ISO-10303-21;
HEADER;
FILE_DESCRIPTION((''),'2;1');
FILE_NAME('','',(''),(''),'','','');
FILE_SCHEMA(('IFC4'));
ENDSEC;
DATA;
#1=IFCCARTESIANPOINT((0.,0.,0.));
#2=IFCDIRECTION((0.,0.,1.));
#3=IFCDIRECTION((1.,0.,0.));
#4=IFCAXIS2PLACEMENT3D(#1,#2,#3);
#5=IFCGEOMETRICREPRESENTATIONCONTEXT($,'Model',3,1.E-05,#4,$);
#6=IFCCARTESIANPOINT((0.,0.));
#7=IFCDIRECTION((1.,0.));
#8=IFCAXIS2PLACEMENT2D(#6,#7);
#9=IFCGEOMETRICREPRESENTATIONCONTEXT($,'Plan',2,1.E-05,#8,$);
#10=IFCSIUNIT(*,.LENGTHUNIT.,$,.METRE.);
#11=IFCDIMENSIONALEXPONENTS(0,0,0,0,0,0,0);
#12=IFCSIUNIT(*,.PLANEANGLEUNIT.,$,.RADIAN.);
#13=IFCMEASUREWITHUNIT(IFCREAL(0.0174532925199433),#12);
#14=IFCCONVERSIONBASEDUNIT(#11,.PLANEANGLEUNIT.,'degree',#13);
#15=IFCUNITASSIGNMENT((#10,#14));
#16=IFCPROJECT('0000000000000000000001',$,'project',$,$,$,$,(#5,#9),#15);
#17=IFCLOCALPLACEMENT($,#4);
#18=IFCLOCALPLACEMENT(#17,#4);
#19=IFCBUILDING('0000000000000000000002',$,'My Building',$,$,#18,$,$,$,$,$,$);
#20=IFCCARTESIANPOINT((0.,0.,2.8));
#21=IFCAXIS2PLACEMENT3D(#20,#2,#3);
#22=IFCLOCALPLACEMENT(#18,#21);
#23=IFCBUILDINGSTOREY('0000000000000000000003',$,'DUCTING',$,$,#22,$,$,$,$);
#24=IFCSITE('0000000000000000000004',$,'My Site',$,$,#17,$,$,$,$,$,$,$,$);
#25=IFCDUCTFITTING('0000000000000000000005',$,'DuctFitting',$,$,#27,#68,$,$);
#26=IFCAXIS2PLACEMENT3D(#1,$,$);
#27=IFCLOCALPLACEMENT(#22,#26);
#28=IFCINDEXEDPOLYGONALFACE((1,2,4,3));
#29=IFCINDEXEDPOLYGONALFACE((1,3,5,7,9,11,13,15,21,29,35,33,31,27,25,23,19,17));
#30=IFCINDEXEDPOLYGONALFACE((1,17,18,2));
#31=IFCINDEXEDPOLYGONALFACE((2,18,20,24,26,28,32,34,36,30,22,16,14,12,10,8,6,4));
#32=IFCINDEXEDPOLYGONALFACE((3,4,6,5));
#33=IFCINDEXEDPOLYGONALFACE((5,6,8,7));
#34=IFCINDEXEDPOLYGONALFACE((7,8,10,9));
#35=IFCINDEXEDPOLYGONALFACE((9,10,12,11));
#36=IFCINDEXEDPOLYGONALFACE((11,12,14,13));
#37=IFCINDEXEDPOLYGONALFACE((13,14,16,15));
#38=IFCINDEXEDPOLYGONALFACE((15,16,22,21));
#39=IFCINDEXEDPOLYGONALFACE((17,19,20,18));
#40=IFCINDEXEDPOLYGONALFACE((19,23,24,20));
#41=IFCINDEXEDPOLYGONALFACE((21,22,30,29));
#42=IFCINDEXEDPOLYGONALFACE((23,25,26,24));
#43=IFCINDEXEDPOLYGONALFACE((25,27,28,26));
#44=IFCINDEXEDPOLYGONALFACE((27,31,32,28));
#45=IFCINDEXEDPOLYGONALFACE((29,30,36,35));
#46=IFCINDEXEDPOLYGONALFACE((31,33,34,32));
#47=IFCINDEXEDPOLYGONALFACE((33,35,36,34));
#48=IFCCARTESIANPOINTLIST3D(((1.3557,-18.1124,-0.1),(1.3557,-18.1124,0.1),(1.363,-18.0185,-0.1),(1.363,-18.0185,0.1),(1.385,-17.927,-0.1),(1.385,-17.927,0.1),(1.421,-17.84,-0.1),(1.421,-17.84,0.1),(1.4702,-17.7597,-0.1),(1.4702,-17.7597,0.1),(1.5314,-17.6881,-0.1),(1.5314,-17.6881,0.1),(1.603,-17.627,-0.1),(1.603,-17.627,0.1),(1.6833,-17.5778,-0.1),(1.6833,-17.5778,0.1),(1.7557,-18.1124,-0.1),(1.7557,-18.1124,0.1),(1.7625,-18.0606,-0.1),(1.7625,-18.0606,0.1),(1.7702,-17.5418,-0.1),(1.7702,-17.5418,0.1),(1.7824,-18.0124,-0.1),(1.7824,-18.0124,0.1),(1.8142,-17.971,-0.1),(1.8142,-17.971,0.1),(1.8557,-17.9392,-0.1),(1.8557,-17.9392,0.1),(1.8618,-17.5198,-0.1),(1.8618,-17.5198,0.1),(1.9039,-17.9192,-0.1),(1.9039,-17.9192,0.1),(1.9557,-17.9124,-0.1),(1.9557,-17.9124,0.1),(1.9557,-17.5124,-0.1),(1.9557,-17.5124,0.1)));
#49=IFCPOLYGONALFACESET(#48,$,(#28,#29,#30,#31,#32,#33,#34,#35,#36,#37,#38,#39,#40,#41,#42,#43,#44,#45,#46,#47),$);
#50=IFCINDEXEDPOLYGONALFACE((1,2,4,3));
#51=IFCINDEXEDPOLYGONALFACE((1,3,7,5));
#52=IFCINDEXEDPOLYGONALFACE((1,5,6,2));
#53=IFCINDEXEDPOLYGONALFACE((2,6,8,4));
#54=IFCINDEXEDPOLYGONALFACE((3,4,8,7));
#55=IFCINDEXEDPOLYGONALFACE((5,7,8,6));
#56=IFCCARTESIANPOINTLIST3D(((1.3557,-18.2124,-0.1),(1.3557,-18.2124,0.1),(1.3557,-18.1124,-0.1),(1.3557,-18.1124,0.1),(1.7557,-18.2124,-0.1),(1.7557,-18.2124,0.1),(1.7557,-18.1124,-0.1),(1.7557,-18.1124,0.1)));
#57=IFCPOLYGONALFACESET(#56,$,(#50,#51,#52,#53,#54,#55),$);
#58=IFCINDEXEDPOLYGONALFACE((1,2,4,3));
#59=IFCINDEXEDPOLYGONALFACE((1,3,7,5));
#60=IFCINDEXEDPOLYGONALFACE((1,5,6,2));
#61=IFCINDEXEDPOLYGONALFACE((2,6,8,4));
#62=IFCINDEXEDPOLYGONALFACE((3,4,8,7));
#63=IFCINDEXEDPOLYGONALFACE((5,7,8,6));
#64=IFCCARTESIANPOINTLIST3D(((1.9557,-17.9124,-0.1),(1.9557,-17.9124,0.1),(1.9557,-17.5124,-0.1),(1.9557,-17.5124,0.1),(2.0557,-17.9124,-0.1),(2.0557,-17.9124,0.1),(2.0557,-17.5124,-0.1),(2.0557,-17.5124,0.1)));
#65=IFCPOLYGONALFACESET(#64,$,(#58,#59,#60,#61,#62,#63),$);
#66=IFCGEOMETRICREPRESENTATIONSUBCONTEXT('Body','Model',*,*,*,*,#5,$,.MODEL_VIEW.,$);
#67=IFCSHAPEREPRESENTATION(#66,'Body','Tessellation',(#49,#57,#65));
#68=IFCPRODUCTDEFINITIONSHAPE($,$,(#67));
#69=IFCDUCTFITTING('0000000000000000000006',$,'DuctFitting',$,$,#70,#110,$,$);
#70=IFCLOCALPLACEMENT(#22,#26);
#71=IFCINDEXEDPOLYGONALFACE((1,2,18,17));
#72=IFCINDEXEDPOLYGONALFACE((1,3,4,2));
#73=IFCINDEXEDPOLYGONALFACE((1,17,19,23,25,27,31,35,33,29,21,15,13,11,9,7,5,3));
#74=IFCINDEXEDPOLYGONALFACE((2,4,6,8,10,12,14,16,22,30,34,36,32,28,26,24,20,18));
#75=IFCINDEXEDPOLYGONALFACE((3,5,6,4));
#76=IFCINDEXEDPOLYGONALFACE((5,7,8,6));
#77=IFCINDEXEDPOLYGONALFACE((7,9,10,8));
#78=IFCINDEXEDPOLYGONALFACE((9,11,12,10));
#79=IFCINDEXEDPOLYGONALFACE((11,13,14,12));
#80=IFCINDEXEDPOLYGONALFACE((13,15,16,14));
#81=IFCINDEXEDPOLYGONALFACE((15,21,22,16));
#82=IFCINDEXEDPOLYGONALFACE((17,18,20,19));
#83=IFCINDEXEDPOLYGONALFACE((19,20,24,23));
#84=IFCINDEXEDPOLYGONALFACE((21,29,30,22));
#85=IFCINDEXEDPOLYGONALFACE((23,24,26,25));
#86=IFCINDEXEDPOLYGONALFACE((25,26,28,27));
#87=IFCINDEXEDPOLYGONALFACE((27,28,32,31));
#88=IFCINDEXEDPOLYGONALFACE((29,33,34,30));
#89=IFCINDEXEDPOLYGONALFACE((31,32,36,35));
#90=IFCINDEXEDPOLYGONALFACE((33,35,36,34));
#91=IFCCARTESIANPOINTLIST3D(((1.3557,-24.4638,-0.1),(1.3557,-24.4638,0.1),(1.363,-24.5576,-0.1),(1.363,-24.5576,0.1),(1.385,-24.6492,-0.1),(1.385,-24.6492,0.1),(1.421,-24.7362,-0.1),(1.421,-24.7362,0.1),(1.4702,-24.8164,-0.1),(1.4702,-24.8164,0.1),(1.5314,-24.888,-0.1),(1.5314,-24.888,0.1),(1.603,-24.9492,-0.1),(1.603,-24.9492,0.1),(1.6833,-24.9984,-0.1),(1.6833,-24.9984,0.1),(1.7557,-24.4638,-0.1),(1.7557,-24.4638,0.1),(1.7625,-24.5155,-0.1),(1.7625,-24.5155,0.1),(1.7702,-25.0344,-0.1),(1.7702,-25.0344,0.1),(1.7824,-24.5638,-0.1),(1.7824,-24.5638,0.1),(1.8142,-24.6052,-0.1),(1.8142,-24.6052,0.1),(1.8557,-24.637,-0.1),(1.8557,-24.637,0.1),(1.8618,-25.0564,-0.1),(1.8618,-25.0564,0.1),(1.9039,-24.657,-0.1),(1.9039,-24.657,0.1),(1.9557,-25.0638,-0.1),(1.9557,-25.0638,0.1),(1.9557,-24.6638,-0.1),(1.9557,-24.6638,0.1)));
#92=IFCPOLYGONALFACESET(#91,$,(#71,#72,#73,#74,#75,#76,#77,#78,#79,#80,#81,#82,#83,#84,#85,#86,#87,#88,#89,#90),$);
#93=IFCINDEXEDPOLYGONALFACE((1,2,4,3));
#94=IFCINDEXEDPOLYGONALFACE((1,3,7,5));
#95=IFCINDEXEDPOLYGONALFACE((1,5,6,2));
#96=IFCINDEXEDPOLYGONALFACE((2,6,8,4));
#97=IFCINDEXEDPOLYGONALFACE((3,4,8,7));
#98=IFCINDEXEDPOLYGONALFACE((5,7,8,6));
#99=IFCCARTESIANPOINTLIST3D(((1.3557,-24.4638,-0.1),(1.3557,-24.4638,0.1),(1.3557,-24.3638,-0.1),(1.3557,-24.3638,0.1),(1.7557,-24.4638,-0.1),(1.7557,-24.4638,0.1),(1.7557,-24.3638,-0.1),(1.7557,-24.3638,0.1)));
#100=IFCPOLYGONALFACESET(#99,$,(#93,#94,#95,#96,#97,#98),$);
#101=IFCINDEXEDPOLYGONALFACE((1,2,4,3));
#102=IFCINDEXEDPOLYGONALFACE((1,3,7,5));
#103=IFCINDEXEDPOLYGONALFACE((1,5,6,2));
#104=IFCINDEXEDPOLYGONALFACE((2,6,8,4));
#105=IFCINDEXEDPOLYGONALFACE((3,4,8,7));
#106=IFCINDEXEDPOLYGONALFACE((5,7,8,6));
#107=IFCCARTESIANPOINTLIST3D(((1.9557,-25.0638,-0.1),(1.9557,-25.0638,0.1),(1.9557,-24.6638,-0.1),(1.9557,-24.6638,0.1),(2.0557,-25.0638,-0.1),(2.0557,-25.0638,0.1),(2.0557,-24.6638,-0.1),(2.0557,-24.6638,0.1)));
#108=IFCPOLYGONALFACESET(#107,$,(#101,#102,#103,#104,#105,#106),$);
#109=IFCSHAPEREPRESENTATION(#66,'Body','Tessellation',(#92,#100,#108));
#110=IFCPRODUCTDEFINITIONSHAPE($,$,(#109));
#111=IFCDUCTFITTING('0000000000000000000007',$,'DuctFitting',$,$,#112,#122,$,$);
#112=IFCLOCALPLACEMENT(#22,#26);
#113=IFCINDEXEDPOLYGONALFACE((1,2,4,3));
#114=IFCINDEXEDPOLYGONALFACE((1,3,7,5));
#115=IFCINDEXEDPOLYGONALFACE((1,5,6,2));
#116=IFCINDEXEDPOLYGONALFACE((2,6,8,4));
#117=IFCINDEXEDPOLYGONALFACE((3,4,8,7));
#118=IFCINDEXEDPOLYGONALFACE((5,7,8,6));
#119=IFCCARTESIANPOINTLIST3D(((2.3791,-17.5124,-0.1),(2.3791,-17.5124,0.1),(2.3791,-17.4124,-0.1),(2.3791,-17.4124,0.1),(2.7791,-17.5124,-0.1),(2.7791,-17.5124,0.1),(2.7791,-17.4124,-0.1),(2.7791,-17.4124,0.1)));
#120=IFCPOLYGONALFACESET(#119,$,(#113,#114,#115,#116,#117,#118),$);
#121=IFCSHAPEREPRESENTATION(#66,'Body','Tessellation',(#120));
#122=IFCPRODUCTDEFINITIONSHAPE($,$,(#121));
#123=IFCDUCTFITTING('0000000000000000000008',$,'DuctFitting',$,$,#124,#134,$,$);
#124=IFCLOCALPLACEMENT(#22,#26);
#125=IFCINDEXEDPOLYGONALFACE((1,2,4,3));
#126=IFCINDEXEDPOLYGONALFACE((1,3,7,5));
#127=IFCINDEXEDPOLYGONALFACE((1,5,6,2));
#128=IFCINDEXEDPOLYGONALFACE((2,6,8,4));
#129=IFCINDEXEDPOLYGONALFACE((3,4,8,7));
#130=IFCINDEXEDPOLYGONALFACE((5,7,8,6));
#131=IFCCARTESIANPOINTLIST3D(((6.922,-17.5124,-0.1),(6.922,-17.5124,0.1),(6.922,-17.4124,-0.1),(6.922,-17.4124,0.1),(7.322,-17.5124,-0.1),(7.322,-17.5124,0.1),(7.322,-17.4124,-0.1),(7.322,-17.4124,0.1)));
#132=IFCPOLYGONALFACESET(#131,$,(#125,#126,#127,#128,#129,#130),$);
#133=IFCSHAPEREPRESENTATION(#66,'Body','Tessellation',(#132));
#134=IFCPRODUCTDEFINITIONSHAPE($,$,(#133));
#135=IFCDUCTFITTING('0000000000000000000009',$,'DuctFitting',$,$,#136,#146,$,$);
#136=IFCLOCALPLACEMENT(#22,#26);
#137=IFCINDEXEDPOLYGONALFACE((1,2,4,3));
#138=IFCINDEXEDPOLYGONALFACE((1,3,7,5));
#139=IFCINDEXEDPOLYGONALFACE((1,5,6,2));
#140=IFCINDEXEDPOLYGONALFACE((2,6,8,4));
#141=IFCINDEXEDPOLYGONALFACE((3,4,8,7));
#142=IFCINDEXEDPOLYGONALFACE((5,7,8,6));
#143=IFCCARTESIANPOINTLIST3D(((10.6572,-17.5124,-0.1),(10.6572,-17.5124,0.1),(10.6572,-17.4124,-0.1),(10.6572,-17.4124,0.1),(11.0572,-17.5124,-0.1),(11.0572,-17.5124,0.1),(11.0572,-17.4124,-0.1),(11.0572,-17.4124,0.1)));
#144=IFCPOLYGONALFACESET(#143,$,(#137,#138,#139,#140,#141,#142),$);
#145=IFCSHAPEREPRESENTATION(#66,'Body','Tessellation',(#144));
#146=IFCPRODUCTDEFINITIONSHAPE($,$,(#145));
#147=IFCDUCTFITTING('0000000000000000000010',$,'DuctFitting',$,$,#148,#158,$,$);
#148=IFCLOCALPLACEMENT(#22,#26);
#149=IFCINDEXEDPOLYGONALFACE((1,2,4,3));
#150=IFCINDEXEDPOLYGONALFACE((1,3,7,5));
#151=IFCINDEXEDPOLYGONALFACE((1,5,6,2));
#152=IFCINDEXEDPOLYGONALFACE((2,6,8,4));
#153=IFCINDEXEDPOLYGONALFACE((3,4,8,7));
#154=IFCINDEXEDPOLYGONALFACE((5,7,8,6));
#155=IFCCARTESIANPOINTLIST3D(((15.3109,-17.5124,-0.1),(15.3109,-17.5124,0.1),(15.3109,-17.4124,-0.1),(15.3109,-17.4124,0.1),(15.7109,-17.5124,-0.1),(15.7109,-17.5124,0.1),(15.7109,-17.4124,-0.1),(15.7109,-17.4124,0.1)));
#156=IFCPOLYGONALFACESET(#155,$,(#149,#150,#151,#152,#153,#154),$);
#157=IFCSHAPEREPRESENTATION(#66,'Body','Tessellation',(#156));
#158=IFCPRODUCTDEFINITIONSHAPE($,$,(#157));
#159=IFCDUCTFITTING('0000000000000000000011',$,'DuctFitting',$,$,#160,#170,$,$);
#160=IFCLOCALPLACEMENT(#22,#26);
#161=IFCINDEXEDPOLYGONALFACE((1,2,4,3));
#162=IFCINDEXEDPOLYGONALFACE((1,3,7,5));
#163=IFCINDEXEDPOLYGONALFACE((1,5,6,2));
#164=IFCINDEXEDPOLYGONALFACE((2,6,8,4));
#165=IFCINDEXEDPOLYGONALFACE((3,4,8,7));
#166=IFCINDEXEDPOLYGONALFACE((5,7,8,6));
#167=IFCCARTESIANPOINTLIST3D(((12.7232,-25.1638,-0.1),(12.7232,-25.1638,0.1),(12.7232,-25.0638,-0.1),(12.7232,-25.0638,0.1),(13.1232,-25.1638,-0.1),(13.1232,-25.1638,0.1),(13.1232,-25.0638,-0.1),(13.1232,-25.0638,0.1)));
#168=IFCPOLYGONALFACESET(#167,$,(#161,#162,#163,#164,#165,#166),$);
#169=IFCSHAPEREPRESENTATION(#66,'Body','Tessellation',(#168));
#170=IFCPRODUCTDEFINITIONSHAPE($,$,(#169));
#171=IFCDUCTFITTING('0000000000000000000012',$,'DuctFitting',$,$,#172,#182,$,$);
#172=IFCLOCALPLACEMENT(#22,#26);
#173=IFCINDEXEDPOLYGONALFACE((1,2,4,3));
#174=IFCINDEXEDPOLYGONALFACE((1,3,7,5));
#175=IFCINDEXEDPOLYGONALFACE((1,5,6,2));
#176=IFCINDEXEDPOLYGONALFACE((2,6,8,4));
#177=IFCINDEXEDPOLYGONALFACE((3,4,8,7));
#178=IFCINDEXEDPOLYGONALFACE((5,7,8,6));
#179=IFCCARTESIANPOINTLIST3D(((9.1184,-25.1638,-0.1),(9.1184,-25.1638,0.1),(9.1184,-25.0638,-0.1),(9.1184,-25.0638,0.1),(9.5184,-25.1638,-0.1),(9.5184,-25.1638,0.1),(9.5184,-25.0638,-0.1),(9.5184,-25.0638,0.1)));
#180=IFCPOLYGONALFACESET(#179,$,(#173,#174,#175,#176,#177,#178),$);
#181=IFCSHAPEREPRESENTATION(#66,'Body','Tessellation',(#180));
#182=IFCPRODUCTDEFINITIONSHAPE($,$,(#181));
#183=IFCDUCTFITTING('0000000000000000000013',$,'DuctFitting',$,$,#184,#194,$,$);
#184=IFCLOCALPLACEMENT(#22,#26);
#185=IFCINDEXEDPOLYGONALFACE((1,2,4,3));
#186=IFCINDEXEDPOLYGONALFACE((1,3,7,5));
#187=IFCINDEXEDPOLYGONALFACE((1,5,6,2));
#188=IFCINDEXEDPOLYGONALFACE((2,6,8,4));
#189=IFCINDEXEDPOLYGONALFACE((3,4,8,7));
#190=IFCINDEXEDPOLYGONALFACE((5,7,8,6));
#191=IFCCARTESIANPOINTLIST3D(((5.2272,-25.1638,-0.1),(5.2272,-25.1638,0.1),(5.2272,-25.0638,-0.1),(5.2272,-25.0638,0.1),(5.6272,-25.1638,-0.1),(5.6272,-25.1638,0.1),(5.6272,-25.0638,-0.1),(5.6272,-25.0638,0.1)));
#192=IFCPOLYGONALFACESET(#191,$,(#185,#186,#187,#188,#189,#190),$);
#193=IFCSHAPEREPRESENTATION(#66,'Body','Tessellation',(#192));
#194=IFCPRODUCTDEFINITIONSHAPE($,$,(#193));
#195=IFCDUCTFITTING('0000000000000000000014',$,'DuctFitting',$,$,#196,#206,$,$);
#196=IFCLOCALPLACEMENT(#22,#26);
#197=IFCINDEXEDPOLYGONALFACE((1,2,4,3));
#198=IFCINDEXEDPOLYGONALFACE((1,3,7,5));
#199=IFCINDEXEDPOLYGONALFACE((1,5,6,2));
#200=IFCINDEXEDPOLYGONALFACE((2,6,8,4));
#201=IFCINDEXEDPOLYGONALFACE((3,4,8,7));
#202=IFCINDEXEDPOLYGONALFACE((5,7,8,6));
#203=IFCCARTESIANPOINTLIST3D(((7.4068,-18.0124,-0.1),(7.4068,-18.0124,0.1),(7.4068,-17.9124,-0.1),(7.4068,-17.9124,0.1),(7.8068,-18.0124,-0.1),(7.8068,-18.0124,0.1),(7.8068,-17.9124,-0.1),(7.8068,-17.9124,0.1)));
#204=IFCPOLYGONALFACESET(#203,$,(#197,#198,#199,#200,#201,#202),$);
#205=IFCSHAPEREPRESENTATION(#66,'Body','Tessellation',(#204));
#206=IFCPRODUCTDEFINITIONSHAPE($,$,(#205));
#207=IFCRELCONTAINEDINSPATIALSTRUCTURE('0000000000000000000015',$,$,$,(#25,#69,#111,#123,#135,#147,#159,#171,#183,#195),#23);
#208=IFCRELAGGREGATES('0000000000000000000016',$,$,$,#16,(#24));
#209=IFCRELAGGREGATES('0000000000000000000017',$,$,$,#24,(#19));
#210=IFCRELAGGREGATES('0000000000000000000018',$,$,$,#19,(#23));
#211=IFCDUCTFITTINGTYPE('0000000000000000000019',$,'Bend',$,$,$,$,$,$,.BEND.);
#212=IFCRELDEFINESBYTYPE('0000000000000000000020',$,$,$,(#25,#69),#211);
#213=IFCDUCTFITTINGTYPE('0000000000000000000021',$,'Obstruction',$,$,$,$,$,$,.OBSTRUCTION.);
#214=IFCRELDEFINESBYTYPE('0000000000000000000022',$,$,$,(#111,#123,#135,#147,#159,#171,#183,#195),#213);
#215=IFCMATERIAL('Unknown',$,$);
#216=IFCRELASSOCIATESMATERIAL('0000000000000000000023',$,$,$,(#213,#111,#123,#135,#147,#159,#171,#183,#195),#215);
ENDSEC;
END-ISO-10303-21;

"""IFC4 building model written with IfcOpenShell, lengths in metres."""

from ifc_helpers import new_model, entity, si_unit, converted_unit, frame, origin_with_axes, origin_2d_with_axis, place, context, subcontext, project, spatial, line, arc, indexed_curve, rectangle, outline, extrude, source, transform, mapped, material, material_profile, profile_set, profile_usage, type_object, type_shapes, element, save


model = new_model("IFC4")

# Units and contexts
model_context = context("Model", 3, precision=1e-05, world=origin_with_axes())
plan_context = context("Plan", 2, precision=1e-05, world=origin_2d_with_axis())
body_context = subcontext(model_context, "Body", "Model", "MODEL_VIEW")
ifc_project = project(units=[si_unit("LENGTHUNIT", "METRE"), converted_unit("PLANEANGLEUNIT", "degree", entity("IfcReal", 0.0174532925199433), si_unit("PLANEANGLEUNIT", "RADIAN"), dimensions=[0, 0, 0, 0, 0, 0, 0])], contexts=[model_context, plan_context])

# Site, building, storey
site_placement = place(None, origin_with_axes())
site = spatial("IfcSite", under=ifc_project, at=site_placement, Name="My Site")
building_placement = place(site_placement, origin_with_axes())
building = spatial("IfcBuilding", under=site, at=building_placement, Name="My Building")
storey_placement = place(building_placement, frame((0.0, 0.0, 2.8), z_axis=(0.0, 0.0, 1.0), x_axis=(1.0, 0.0, 0.0)))
storey = spatial("IfcBuildingStorey", under=building, at=storey_placement, Name="DUCTING")

# Shared definitions
ifc_material = material(Name="Unknown")

# Duct fittings
duct_fitting_type_1 = type_object("IfcDuctFittingType", Name="Bend", PredefinedType="BEND")
shared_shape = source(origin_with_axes(), body_context, "Body", "SweptSolid", [
    extrude(outline(indexed_curve([(0.2, 0.0), (0.2586, -0.1414), (0.4, -0.2), (0.4, -0.6), (-0.0243, -0.4243), (-0.2, 0.0)], segments=[arc(1, 2, 3), line(3, 4), arc(4, 5, 6), line(6, 1)])), frame((0.0, -0.1, -0.1), z_axis=(0.0, -1.0, 0.0), x_axis=(1.0, 0.0, 0.0)), (0.0, 0.0, -1.0), 0.2),
    extrude(rectangle(XDim=0.4, YDim=0.2), origin_with_axes(), (0.0, 0.0, -1.0), 0.1),
    extrude(rectangle(XDim=0.4, YDim=0.2), frame((0.4, 0.0, -0.5), z_axis=(1.0, 0.0, 0.0), x_axis=(0.0, 0.0, 1.0)), (0.0, 0.0, 1.0), 0.1),
])
type_shapes(duct_fitting_type_1, [shared_shape])
for number, where, z_axis, x_axis, name in (
    (1, (1.5557, -18.2124, 0.0), (0.0, -1.0, 0.0), (1.0, 0.0, 0.0), "DuctFitting"),
    (2, (1.5557, -24.3638, 0.0), (0.0, 1.0, 0.0), (1.0, 0.0, 0.0), "DuctFitting"),
):
    element("IfcDuctFitting", number, at=place(storey_placement, frame(where, z_axis=z_axis, x_axis=x_axis)), inside=storey, type_object=duct_fitting_type_1, Name=name, context=body_context, shape_type="MappedRepresentation", body=[
        mapped(shared_shape, transform((0.0, 0.0, 0.0), x_axis=(1.0, 0.0, 0.0), y_axis=(0.0, 1.0, 0.0), z_axis=(0.0, 0.0, 1.0), scale=1.0)),
    ])
ifc_material_profile_1 = material_profile(ifc_material, rectangle(XDim=0.4, YDim=0.2))
ifc_profile_set_1 = profile_set([ifc_material_profile_1])
ifc_profile_usage_1 = profile_usage(ifc_profile_set_1, cardinal=5)
duct_fitting_type_2 = type_object("IfcDuctFittingType", Name="Obstruction", PredefinedType="OBSTRUCTION", material=ifc_profile_set_1)
duct_fitting_1_placement = place(storey_placement, frame((2.5791, -17.5124, 0.0), z_axis=(0.0, 1.0, 0.0), x_axis=(-1.0, 0.0, 0.0)))
element("IfcDuctFitting", 3, at=duct_fitting_1_placement, inside=storey, type_object=duct_fitting_type_2, material=ifc_profile_usage_1, Name="DuctFitting", context=body_context, shape_type="SweptSolid", body=[
    extrude(rectangle(XDim=0.4, YDim=0.2), origin_with_axes(), (0.0, 0.0, 1.0), 0.1),
])
ifc_profile_usage_2 = profile_usage(ifc_profile_set_1, cardinal=5)
duct_fitting_2_placement = place(storey_placement, frame((7.122, -17.5124, 0.0), z_axis=(0.0, 1.0, 0.0), x_axis=(-1.0, 0.0, 0.0)))
element("IfcDuctFitting", 4, at=duct_fitting_2_placement, inside=storey, type_object=duct_fitting_type_2, material=ifc_profile_usage_2, Name="DuctFitting", context=body_context, shape_type="SweptSolid", body=[
    extrude(rectangle(XDim=0.4, YDim=0.2), origin_with_axes(), (0.0, 0.0, 1.0), 0.1),
])
ifc_profile_usage_3 = profile_usage(ifc_profile_set_1, cardinal=5)
duct_fitting_3_placement = place(storey_placement, frame((10.8572, -17.5124, 0.0), z_axis=(0.0, 1.0, 0.0), x_axis=(-1.0, 0.0, 0.0)))
element("IfcDuctFitting", 5, at=duct_fitting_3_placement, inside=storey, type_object=duct_fitting_type_2, material=ifc_profile_usage_3, Name="DuctFitting", context=body_context, shape_type="SweptSolid", body=[
    extrude(rectangle(XDim=0.4, YDim=0.2), origin_with_axes(), (0.0, 0.0, 1.0), 0.1),
])
ifc_profile_usage_4 = profile_usage(ifc_profile_set_1, cardinal=5)
duct_fitting_4_placement = place(storey_placement, frame((15.5109, -17.5124, 0.0), z_axis=(0.0, 1.0, 0.0), x_axis=(-1.0, 0.0, 0.0)))
element("IfcDuctFitting", 6, at=duct_fitting_4_placement, inside=storey, type_object=duct_fitting_type_2, material=ifc_profile_usage_4, Name="DuctFitting", context=body_context, shape_type="SweptSolid", body=[
    extrude(rectangle(XDim=0.4, YDim=0.2), origin_with_axes(), (0.0, 0.0, 1.0), 0.1),
])
ifc_profile_usage_5 = profile_usage(ifc_profile_set_1, cardinal=5)
duct_fitting_5_placement = place(storey_placement, frame((12.9232, -25.0638, 0.0), z_axis=(0.0, -1.0, 0.0), x_axis=(1.0, 0.0, 0.0)))
element("IfcDuctFitting", 7, at=duct_fitting_5_placement, inside=storey, type_object=duct_fitting_type_2, material=ifc_profile_usage_5, Name="DuctFitting", context=body_context, shape_type="SweptSolid", body=[
    extrude(rectangle(XDim=0.4, YDim=0.2), origin_with_axes(), (0.0, 0.0, 1.0), 0.1),
])
ifc_profile_usage_6 = profile_usage(ifc_profile_set_1, cardinal=5)
duct_fitting_6_placement = place(storey_placement, frame((9.3184, -25.0638, 0.0), z_axis=(0.0, -1.0, 0.0), x_axis=(1.0, 0.0, 0.0)))
element("IfcDuctFitting", 8, at=duct_fitting_6_placement, inside=storey, type_object=duct_fitting_type_2, material=ifc_profile_usage_6, Name="DuctFitting", context=body_context, shape_type="SweptSolid", body=[
    extrude(rectangle(XDim=0.4, YDim=0.2), origin_with_axes(), (0.0, 0.0, 1.0), 0.1),
])
ifc_profile_usage_7 = profile_usage(ifc_profile_set_1, cardinal=5)
duct_fitting_7_placement = place(storey_placement, frame((5.4272, -25.0638, 0.0), z_axis=(0.0, -1.0, 0.0), x_axis=(1.0, 0.0, 0.0)))
element("IfcDuctFitting", 9, at=duct_fitting_7_placement, inside=storey, type_object=duct_fitting_type_2, material=ifc_profile_usage_7, Name="DuctFitting", context=body_context, shape_type="SweptSolid", body=[
    extrude(rectangle(XDim=0.4, YDim=0.2), origin_with_axes(), (0.0, 0.0, 1.0), 0.1),
])
ifc_profile_usage_8 = profile_usage(ifc_profile_set_1, cardinal=5)
duct_fitting_8_placement = place(storey_placement, frame((7.6068, -17.9124, 0.0), z_axis=(0.0, -1.0, 0.0), x_axis=(1.0, 0.0, 0.0)))
element("IfcDuctFitting", 10, at=duct_fitting_8_placement, inside=storey, type_object=duct_fitting_type_2, material=ifc_profile_usage_8, Name="DuctFitting", context=body_context, shape_type="SweptSolid", body=[
    extrude(rectangle(XDim=0.4, YDim=0.2), origin_with_axes(), (0.0, 0.0, 1.0), 0.1),
])

save(model, "model.ifc")
